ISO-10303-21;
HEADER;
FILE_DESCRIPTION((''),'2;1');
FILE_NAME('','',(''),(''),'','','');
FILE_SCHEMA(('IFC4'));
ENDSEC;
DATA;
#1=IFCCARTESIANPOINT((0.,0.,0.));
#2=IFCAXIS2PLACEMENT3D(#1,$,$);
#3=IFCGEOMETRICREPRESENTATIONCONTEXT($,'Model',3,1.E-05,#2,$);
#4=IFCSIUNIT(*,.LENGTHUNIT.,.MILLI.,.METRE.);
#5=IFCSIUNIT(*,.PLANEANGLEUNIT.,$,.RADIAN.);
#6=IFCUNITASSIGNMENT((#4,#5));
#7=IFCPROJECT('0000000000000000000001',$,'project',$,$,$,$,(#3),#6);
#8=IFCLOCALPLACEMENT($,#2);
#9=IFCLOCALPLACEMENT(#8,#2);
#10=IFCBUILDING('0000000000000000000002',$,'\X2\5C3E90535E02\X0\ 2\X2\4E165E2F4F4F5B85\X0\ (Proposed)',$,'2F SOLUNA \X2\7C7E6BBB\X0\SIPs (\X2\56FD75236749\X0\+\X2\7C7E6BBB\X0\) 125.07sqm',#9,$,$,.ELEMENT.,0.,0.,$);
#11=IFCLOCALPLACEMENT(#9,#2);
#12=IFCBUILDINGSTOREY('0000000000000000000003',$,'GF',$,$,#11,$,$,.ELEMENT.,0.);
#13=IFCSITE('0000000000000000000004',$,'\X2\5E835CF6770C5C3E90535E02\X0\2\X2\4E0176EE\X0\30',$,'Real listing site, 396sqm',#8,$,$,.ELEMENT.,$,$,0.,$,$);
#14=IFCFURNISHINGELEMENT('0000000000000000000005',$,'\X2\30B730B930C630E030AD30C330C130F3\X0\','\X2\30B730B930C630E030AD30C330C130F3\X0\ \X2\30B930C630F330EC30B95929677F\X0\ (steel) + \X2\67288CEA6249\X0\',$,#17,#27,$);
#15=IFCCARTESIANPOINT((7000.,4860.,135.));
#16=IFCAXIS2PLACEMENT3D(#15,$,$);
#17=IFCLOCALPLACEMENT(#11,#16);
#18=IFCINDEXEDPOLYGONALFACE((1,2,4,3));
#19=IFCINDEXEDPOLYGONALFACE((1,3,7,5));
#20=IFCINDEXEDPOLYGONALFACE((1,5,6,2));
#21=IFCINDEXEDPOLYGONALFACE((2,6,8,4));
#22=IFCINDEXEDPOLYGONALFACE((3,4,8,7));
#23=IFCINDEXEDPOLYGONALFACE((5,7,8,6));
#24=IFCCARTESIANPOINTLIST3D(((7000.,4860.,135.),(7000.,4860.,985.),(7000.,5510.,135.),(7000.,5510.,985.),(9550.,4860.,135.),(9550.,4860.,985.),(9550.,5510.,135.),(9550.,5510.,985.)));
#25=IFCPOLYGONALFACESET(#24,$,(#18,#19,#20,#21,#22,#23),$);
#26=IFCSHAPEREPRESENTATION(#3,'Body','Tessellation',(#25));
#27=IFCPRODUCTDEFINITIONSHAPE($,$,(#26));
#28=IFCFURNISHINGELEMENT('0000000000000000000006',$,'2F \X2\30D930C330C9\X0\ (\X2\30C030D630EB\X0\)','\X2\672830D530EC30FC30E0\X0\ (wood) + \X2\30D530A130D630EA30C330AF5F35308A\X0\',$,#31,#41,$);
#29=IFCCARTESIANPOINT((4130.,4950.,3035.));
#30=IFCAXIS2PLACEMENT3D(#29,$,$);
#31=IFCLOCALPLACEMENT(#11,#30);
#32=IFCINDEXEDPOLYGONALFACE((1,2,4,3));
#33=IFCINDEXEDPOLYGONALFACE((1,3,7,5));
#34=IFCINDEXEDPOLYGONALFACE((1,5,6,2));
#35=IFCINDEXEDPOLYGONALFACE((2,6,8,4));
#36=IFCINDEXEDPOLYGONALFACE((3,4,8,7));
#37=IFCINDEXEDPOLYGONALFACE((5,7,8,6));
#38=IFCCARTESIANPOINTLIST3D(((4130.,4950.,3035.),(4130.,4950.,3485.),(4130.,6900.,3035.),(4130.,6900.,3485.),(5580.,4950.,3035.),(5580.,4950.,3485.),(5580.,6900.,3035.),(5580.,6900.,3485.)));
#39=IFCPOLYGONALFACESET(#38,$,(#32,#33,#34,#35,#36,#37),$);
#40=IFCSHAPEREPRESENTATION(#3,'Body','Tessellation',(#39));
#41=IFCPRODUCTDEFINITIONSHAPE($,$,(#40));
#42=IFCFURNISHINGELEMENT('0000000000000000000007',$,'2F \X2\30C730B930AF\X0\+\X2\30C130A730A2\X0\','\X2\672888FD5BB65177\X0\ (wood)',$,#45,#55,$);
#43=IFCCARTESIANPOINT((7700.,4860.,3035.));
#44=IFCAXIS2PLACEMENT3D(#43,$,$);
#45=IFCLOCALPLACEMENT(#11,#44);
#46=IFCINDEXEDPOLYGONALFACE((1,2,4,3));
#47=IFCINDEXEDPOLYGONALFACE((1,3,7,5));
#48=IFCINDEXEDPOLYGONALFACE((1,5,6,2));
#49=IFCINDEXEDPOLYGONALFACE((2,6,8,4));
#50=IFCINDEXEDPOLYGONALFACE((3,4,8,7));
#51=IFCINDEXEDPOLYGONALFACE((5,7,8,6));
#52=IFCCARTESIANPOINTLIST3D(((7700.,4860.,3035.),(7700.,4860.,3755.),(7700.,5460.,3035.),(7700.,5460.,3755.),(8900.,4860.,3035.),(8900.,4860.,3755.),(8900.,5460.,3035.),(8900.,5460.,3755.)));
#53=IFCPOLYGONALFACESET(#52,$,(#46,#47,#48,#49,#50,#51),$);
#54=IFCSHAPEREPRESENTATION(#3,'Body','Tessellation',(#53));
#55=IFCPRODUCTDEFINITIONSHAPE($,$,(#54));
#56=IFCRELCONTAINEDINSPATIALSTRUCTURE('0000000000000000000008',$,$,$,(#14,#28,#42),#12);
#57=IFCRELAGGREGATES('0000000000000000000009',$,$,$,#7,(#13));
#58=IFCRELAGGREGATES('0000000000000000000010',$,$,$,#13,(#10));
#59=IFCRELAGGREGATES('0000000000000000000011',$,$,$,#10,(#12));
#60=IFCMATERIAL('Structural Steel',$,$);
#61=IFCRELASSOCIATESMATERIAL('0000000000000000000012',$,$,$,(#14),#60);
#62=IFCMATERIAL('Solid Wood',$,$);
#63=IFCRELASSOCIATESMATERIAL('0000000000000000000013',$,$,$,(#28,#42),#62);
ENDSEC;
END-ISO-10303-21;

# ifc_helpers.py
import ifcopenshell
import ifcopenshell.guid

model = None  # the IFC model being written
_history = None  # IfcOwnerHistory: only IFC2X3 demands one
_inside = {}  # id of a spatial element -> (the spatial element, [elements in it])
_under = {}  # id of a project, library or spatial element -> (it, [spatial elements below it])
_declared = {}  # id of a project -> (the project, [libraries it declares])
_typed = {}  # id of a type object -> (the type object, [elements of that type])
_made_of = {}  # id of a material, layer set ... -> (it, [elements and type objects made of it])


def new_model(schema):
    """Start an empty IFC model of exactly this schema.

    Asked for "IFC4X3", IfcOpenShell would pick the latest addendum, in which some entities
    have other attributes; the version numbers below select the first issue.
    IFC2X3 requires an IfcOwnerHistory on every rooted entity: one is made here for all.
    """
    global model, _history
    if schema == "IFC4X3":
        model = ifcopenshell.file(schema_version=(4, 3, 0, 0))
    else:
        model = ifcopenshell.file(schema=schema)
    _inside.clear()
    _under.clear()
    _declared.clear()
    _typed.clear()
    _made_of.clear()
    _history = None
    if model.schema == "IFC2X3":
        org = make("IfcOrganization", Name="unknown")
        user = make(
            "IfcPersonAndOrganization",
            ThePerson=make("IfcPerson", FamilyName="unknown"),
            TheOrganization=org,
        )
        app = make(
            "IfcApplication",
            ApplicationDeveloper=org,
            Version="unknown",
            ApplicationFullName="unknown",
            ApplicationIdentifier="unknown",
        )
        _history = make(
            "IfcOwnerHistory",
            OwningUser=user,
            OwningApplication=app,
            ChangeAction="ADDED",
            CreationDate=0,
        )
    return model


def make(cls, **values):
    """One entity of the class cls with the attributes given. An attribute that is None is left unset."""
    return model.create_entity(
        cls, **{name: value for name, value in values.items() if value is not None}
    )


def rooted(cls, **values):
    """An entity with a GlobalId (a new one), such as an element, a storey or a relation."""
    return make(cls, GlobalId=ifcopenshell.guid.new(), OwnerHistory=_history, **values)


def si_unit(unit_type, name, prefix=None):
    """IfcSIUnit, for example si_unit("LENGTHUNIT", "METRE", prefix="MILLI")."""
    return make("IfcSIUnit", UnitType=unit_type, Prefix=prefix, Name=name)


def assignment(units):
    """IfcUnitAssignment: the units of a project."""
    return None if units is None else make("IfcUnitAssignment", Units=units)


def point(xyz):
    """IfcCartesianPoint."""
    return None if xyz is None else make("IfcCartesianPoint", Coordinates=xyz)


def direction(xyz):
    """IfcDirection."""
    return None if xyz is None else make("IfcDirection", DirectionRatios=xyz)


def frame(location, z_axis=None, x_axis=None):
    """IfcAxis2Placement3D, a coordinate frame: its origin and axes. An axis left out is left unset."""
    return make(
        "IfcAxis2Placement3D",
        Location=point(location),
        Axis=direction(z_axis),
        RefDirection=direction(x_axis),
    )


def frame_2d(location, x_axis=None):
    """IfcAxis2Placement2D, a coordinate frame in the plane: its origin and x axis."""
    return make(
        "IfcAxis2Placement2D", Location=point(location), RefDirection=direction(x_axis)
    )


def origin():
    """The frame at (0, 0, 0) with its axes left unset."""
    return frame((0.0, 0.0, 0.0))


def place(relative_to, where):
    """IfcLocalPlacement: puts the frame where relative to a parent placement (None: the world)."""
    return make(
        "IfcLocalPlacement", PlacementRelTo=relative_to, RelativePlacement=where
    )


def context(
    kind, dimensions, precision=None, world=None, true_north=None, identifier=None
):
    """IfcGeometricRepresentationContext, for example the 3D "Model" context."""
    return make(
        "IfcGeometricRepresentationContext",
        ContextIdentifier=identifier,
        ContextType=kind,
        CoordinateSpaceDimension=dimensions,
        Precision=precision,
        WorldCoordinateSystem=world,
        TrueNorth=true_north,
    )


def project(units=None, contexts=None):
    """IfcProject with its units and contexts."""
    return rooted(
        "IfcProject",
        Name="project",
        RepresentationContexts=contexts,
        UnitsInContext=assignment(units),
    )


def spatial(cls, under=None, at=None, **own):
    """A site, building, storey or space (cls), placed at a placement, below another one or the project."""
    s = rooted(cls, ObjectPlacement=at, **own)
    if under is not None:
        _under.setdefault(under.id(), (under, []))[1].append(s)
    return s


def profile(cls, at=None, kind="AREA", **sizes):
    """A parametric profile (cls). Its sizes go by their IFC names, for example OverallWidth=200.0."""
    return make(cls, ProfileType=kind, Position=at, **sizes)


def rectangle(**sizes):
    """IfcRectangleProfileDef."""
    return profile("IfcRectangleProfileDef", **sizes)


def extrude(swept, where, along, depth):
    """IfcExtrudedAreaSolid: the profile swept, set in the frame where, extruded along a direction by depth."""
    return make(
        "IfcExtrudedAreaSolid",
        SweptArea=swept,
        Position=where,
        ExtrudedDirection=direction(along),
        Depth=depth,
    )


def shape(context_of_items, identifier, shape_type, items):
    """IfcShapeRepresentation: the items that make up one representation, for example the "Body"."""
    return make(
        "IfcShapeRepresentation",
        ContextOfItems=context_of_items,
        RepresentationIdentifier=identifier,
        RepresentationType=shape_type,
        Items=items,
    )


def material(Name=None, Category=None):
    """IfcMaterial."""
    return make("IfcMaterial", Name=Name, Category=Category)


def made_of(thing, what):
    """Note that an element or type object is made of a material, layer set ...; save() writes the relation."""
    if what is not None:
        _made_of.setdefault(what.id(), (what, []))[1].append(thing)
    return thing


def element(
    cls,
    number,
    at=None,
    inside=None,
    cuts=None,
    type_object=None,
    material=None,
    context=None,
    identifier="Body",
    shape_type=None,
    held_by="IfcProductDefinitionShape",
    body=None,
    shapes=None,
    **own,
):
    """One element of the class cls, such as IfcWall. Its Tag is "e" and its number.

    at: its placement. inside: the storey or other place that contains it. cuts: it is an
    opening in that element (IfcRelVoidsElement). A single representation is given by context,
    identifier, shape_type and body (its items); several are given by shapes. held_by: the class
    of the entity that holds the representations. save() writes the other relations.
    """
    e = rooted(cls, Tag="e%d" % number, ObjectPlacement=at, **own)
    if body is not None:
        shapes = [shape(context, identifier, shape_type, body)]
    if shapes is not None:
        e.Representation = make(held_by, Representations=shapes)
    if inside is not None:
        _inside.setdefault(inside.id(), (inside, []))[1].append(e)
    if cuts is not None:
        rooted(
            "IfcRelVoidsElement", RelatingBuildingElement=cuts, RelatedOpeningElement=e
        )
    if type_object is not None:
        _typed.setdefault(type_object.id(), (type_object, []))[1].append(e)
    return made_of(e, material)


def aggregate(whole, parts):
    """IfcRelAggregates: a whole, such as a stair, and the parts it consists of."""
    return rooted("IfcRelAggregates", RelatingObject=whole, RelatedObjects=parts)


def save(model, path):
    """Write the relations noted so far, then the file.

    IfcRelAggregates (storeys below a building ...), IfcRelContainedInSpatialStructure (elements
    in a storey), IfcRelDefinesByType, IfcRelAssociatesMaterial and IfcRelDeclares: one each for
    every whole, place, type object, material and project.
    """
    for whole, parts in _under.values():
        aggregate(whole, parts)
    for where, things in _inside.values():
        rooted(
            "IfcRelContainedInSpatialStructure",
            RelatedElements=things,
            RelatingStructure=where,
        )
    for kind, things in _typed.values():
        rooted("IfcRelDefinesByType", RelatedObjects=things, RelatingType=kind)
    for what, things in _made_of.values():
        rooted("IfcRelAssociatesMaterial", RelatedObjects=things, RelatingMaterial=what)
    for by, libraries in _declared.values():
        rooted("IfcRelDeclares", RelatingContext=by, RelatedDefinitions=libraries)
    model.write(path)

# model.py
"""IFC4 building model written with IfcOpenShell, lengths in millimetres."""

from ifc_helpers import new_model, si_unit, frame, frame_2d, origin, place, context, project, spatial, rectangle, extrude, material, element, save


model = new_model("IFC4")

# Units and contexts
model_context = context("Model", 3, precision=1e-05, world=origin())
ifc_project = project(units=[si_unit("LENGTHUNIT", "METRE", prefix="MILLI"), si_unit("PLANEANGLEUNIT", "RADIAN")], contexts=[model_context])

# Site, building, storey
site_placement = place(None, origin())
site = spatial("IfcSite", under=ifc_project, at=site_placement, Name="広島県尾道市2丁目30", ObjectType="Real listing site, 396sqm", CompositionType="ELEMENT", RefElevation=0.0)
building_placement = place(site_placement, origin())
building = spatial("IfcBuilding", under=site, at=building_placement, Name="尾道市 2世帯住宅 (Proposed)", ObjectType="2F SOLUNA 籾殻SIPs (国産杉+籾殻) 125.07sqm", CompositionType="ELEMENT", ElevationOfRefHeight=0.0, ElevationOfTerrain=0.0)
storey_placement = place(building_placement, origin())
storey = spatial("IfcBuildingStorey", under=building, at=storey_placement, Name="GF", CompositionType="ELEMENT", Elevation=0.0)

# Shared definitions
ifc_material_1 = material(Name="Solid Wood")

# Furnishing elements
ifc_material_2 = material(Name="Structural Steel")
furnishing_1_placement = place(storey_placement, frame((7000.0, 4860.0, 135.0)))
element("IfcFurnishingElement", 1, at=furnishing_1_placement, inside=storey, material=ifc_material_2, Name="システムキッチン", Description="システムキッチン ステンレス天板 (steel) + 木質扉", context=model_context, shape_type="SweptSolid", body=[
    extrude(rectangle(XDim=2550.0, YDim=650.0, at=frame_2d((1275.0, 325.0))), frame((7000.0, 4860.0, 135.0)), (0.0, 0.0, 1.0), 850.0),
])
furnishing_2_placement = place(storey_placement, frame((4130.0, 4950.0, 3035.0)))
element("IfcFurnishingElement", 2, at=furnishing_2_placement, inside=storey, material=ifc_material_1, Name="2F ベッド (ダブル)", Description="木フレーム (wood) + ファブリック張り", context=model_context, shape_type="SweptSolid", body=[
    extrude(rectangle(XDim=1450.0, YDim=1950.0, at=frame_2d((725.0, 975.0))), frame((4130.0, 4950.0, 3035.0)), (0.0, 0.0, 1.0), 450.0),
])
furnishing_3_placement = place(storey_placement, frame((7700.0, 4860.0, 3035.0)))
element("IfcFurnishingElement", 3, at=furnishing_3_placement, inside=storey, material=ifc_material_1, Name="2F デスク+チェア", Description="木製家具 (wood)", context=model_context, shape_type="SweptSolid", body=[
    extrude(rectangle(XDim=1200.0, YDim=600.0, at=frame_2d((600.0, 300.0))), frame((7700.0, 4860.0, 3035.0)), (0.0, 0.0, 1.0), 720.0),
])

save(model, "model.ifc")
